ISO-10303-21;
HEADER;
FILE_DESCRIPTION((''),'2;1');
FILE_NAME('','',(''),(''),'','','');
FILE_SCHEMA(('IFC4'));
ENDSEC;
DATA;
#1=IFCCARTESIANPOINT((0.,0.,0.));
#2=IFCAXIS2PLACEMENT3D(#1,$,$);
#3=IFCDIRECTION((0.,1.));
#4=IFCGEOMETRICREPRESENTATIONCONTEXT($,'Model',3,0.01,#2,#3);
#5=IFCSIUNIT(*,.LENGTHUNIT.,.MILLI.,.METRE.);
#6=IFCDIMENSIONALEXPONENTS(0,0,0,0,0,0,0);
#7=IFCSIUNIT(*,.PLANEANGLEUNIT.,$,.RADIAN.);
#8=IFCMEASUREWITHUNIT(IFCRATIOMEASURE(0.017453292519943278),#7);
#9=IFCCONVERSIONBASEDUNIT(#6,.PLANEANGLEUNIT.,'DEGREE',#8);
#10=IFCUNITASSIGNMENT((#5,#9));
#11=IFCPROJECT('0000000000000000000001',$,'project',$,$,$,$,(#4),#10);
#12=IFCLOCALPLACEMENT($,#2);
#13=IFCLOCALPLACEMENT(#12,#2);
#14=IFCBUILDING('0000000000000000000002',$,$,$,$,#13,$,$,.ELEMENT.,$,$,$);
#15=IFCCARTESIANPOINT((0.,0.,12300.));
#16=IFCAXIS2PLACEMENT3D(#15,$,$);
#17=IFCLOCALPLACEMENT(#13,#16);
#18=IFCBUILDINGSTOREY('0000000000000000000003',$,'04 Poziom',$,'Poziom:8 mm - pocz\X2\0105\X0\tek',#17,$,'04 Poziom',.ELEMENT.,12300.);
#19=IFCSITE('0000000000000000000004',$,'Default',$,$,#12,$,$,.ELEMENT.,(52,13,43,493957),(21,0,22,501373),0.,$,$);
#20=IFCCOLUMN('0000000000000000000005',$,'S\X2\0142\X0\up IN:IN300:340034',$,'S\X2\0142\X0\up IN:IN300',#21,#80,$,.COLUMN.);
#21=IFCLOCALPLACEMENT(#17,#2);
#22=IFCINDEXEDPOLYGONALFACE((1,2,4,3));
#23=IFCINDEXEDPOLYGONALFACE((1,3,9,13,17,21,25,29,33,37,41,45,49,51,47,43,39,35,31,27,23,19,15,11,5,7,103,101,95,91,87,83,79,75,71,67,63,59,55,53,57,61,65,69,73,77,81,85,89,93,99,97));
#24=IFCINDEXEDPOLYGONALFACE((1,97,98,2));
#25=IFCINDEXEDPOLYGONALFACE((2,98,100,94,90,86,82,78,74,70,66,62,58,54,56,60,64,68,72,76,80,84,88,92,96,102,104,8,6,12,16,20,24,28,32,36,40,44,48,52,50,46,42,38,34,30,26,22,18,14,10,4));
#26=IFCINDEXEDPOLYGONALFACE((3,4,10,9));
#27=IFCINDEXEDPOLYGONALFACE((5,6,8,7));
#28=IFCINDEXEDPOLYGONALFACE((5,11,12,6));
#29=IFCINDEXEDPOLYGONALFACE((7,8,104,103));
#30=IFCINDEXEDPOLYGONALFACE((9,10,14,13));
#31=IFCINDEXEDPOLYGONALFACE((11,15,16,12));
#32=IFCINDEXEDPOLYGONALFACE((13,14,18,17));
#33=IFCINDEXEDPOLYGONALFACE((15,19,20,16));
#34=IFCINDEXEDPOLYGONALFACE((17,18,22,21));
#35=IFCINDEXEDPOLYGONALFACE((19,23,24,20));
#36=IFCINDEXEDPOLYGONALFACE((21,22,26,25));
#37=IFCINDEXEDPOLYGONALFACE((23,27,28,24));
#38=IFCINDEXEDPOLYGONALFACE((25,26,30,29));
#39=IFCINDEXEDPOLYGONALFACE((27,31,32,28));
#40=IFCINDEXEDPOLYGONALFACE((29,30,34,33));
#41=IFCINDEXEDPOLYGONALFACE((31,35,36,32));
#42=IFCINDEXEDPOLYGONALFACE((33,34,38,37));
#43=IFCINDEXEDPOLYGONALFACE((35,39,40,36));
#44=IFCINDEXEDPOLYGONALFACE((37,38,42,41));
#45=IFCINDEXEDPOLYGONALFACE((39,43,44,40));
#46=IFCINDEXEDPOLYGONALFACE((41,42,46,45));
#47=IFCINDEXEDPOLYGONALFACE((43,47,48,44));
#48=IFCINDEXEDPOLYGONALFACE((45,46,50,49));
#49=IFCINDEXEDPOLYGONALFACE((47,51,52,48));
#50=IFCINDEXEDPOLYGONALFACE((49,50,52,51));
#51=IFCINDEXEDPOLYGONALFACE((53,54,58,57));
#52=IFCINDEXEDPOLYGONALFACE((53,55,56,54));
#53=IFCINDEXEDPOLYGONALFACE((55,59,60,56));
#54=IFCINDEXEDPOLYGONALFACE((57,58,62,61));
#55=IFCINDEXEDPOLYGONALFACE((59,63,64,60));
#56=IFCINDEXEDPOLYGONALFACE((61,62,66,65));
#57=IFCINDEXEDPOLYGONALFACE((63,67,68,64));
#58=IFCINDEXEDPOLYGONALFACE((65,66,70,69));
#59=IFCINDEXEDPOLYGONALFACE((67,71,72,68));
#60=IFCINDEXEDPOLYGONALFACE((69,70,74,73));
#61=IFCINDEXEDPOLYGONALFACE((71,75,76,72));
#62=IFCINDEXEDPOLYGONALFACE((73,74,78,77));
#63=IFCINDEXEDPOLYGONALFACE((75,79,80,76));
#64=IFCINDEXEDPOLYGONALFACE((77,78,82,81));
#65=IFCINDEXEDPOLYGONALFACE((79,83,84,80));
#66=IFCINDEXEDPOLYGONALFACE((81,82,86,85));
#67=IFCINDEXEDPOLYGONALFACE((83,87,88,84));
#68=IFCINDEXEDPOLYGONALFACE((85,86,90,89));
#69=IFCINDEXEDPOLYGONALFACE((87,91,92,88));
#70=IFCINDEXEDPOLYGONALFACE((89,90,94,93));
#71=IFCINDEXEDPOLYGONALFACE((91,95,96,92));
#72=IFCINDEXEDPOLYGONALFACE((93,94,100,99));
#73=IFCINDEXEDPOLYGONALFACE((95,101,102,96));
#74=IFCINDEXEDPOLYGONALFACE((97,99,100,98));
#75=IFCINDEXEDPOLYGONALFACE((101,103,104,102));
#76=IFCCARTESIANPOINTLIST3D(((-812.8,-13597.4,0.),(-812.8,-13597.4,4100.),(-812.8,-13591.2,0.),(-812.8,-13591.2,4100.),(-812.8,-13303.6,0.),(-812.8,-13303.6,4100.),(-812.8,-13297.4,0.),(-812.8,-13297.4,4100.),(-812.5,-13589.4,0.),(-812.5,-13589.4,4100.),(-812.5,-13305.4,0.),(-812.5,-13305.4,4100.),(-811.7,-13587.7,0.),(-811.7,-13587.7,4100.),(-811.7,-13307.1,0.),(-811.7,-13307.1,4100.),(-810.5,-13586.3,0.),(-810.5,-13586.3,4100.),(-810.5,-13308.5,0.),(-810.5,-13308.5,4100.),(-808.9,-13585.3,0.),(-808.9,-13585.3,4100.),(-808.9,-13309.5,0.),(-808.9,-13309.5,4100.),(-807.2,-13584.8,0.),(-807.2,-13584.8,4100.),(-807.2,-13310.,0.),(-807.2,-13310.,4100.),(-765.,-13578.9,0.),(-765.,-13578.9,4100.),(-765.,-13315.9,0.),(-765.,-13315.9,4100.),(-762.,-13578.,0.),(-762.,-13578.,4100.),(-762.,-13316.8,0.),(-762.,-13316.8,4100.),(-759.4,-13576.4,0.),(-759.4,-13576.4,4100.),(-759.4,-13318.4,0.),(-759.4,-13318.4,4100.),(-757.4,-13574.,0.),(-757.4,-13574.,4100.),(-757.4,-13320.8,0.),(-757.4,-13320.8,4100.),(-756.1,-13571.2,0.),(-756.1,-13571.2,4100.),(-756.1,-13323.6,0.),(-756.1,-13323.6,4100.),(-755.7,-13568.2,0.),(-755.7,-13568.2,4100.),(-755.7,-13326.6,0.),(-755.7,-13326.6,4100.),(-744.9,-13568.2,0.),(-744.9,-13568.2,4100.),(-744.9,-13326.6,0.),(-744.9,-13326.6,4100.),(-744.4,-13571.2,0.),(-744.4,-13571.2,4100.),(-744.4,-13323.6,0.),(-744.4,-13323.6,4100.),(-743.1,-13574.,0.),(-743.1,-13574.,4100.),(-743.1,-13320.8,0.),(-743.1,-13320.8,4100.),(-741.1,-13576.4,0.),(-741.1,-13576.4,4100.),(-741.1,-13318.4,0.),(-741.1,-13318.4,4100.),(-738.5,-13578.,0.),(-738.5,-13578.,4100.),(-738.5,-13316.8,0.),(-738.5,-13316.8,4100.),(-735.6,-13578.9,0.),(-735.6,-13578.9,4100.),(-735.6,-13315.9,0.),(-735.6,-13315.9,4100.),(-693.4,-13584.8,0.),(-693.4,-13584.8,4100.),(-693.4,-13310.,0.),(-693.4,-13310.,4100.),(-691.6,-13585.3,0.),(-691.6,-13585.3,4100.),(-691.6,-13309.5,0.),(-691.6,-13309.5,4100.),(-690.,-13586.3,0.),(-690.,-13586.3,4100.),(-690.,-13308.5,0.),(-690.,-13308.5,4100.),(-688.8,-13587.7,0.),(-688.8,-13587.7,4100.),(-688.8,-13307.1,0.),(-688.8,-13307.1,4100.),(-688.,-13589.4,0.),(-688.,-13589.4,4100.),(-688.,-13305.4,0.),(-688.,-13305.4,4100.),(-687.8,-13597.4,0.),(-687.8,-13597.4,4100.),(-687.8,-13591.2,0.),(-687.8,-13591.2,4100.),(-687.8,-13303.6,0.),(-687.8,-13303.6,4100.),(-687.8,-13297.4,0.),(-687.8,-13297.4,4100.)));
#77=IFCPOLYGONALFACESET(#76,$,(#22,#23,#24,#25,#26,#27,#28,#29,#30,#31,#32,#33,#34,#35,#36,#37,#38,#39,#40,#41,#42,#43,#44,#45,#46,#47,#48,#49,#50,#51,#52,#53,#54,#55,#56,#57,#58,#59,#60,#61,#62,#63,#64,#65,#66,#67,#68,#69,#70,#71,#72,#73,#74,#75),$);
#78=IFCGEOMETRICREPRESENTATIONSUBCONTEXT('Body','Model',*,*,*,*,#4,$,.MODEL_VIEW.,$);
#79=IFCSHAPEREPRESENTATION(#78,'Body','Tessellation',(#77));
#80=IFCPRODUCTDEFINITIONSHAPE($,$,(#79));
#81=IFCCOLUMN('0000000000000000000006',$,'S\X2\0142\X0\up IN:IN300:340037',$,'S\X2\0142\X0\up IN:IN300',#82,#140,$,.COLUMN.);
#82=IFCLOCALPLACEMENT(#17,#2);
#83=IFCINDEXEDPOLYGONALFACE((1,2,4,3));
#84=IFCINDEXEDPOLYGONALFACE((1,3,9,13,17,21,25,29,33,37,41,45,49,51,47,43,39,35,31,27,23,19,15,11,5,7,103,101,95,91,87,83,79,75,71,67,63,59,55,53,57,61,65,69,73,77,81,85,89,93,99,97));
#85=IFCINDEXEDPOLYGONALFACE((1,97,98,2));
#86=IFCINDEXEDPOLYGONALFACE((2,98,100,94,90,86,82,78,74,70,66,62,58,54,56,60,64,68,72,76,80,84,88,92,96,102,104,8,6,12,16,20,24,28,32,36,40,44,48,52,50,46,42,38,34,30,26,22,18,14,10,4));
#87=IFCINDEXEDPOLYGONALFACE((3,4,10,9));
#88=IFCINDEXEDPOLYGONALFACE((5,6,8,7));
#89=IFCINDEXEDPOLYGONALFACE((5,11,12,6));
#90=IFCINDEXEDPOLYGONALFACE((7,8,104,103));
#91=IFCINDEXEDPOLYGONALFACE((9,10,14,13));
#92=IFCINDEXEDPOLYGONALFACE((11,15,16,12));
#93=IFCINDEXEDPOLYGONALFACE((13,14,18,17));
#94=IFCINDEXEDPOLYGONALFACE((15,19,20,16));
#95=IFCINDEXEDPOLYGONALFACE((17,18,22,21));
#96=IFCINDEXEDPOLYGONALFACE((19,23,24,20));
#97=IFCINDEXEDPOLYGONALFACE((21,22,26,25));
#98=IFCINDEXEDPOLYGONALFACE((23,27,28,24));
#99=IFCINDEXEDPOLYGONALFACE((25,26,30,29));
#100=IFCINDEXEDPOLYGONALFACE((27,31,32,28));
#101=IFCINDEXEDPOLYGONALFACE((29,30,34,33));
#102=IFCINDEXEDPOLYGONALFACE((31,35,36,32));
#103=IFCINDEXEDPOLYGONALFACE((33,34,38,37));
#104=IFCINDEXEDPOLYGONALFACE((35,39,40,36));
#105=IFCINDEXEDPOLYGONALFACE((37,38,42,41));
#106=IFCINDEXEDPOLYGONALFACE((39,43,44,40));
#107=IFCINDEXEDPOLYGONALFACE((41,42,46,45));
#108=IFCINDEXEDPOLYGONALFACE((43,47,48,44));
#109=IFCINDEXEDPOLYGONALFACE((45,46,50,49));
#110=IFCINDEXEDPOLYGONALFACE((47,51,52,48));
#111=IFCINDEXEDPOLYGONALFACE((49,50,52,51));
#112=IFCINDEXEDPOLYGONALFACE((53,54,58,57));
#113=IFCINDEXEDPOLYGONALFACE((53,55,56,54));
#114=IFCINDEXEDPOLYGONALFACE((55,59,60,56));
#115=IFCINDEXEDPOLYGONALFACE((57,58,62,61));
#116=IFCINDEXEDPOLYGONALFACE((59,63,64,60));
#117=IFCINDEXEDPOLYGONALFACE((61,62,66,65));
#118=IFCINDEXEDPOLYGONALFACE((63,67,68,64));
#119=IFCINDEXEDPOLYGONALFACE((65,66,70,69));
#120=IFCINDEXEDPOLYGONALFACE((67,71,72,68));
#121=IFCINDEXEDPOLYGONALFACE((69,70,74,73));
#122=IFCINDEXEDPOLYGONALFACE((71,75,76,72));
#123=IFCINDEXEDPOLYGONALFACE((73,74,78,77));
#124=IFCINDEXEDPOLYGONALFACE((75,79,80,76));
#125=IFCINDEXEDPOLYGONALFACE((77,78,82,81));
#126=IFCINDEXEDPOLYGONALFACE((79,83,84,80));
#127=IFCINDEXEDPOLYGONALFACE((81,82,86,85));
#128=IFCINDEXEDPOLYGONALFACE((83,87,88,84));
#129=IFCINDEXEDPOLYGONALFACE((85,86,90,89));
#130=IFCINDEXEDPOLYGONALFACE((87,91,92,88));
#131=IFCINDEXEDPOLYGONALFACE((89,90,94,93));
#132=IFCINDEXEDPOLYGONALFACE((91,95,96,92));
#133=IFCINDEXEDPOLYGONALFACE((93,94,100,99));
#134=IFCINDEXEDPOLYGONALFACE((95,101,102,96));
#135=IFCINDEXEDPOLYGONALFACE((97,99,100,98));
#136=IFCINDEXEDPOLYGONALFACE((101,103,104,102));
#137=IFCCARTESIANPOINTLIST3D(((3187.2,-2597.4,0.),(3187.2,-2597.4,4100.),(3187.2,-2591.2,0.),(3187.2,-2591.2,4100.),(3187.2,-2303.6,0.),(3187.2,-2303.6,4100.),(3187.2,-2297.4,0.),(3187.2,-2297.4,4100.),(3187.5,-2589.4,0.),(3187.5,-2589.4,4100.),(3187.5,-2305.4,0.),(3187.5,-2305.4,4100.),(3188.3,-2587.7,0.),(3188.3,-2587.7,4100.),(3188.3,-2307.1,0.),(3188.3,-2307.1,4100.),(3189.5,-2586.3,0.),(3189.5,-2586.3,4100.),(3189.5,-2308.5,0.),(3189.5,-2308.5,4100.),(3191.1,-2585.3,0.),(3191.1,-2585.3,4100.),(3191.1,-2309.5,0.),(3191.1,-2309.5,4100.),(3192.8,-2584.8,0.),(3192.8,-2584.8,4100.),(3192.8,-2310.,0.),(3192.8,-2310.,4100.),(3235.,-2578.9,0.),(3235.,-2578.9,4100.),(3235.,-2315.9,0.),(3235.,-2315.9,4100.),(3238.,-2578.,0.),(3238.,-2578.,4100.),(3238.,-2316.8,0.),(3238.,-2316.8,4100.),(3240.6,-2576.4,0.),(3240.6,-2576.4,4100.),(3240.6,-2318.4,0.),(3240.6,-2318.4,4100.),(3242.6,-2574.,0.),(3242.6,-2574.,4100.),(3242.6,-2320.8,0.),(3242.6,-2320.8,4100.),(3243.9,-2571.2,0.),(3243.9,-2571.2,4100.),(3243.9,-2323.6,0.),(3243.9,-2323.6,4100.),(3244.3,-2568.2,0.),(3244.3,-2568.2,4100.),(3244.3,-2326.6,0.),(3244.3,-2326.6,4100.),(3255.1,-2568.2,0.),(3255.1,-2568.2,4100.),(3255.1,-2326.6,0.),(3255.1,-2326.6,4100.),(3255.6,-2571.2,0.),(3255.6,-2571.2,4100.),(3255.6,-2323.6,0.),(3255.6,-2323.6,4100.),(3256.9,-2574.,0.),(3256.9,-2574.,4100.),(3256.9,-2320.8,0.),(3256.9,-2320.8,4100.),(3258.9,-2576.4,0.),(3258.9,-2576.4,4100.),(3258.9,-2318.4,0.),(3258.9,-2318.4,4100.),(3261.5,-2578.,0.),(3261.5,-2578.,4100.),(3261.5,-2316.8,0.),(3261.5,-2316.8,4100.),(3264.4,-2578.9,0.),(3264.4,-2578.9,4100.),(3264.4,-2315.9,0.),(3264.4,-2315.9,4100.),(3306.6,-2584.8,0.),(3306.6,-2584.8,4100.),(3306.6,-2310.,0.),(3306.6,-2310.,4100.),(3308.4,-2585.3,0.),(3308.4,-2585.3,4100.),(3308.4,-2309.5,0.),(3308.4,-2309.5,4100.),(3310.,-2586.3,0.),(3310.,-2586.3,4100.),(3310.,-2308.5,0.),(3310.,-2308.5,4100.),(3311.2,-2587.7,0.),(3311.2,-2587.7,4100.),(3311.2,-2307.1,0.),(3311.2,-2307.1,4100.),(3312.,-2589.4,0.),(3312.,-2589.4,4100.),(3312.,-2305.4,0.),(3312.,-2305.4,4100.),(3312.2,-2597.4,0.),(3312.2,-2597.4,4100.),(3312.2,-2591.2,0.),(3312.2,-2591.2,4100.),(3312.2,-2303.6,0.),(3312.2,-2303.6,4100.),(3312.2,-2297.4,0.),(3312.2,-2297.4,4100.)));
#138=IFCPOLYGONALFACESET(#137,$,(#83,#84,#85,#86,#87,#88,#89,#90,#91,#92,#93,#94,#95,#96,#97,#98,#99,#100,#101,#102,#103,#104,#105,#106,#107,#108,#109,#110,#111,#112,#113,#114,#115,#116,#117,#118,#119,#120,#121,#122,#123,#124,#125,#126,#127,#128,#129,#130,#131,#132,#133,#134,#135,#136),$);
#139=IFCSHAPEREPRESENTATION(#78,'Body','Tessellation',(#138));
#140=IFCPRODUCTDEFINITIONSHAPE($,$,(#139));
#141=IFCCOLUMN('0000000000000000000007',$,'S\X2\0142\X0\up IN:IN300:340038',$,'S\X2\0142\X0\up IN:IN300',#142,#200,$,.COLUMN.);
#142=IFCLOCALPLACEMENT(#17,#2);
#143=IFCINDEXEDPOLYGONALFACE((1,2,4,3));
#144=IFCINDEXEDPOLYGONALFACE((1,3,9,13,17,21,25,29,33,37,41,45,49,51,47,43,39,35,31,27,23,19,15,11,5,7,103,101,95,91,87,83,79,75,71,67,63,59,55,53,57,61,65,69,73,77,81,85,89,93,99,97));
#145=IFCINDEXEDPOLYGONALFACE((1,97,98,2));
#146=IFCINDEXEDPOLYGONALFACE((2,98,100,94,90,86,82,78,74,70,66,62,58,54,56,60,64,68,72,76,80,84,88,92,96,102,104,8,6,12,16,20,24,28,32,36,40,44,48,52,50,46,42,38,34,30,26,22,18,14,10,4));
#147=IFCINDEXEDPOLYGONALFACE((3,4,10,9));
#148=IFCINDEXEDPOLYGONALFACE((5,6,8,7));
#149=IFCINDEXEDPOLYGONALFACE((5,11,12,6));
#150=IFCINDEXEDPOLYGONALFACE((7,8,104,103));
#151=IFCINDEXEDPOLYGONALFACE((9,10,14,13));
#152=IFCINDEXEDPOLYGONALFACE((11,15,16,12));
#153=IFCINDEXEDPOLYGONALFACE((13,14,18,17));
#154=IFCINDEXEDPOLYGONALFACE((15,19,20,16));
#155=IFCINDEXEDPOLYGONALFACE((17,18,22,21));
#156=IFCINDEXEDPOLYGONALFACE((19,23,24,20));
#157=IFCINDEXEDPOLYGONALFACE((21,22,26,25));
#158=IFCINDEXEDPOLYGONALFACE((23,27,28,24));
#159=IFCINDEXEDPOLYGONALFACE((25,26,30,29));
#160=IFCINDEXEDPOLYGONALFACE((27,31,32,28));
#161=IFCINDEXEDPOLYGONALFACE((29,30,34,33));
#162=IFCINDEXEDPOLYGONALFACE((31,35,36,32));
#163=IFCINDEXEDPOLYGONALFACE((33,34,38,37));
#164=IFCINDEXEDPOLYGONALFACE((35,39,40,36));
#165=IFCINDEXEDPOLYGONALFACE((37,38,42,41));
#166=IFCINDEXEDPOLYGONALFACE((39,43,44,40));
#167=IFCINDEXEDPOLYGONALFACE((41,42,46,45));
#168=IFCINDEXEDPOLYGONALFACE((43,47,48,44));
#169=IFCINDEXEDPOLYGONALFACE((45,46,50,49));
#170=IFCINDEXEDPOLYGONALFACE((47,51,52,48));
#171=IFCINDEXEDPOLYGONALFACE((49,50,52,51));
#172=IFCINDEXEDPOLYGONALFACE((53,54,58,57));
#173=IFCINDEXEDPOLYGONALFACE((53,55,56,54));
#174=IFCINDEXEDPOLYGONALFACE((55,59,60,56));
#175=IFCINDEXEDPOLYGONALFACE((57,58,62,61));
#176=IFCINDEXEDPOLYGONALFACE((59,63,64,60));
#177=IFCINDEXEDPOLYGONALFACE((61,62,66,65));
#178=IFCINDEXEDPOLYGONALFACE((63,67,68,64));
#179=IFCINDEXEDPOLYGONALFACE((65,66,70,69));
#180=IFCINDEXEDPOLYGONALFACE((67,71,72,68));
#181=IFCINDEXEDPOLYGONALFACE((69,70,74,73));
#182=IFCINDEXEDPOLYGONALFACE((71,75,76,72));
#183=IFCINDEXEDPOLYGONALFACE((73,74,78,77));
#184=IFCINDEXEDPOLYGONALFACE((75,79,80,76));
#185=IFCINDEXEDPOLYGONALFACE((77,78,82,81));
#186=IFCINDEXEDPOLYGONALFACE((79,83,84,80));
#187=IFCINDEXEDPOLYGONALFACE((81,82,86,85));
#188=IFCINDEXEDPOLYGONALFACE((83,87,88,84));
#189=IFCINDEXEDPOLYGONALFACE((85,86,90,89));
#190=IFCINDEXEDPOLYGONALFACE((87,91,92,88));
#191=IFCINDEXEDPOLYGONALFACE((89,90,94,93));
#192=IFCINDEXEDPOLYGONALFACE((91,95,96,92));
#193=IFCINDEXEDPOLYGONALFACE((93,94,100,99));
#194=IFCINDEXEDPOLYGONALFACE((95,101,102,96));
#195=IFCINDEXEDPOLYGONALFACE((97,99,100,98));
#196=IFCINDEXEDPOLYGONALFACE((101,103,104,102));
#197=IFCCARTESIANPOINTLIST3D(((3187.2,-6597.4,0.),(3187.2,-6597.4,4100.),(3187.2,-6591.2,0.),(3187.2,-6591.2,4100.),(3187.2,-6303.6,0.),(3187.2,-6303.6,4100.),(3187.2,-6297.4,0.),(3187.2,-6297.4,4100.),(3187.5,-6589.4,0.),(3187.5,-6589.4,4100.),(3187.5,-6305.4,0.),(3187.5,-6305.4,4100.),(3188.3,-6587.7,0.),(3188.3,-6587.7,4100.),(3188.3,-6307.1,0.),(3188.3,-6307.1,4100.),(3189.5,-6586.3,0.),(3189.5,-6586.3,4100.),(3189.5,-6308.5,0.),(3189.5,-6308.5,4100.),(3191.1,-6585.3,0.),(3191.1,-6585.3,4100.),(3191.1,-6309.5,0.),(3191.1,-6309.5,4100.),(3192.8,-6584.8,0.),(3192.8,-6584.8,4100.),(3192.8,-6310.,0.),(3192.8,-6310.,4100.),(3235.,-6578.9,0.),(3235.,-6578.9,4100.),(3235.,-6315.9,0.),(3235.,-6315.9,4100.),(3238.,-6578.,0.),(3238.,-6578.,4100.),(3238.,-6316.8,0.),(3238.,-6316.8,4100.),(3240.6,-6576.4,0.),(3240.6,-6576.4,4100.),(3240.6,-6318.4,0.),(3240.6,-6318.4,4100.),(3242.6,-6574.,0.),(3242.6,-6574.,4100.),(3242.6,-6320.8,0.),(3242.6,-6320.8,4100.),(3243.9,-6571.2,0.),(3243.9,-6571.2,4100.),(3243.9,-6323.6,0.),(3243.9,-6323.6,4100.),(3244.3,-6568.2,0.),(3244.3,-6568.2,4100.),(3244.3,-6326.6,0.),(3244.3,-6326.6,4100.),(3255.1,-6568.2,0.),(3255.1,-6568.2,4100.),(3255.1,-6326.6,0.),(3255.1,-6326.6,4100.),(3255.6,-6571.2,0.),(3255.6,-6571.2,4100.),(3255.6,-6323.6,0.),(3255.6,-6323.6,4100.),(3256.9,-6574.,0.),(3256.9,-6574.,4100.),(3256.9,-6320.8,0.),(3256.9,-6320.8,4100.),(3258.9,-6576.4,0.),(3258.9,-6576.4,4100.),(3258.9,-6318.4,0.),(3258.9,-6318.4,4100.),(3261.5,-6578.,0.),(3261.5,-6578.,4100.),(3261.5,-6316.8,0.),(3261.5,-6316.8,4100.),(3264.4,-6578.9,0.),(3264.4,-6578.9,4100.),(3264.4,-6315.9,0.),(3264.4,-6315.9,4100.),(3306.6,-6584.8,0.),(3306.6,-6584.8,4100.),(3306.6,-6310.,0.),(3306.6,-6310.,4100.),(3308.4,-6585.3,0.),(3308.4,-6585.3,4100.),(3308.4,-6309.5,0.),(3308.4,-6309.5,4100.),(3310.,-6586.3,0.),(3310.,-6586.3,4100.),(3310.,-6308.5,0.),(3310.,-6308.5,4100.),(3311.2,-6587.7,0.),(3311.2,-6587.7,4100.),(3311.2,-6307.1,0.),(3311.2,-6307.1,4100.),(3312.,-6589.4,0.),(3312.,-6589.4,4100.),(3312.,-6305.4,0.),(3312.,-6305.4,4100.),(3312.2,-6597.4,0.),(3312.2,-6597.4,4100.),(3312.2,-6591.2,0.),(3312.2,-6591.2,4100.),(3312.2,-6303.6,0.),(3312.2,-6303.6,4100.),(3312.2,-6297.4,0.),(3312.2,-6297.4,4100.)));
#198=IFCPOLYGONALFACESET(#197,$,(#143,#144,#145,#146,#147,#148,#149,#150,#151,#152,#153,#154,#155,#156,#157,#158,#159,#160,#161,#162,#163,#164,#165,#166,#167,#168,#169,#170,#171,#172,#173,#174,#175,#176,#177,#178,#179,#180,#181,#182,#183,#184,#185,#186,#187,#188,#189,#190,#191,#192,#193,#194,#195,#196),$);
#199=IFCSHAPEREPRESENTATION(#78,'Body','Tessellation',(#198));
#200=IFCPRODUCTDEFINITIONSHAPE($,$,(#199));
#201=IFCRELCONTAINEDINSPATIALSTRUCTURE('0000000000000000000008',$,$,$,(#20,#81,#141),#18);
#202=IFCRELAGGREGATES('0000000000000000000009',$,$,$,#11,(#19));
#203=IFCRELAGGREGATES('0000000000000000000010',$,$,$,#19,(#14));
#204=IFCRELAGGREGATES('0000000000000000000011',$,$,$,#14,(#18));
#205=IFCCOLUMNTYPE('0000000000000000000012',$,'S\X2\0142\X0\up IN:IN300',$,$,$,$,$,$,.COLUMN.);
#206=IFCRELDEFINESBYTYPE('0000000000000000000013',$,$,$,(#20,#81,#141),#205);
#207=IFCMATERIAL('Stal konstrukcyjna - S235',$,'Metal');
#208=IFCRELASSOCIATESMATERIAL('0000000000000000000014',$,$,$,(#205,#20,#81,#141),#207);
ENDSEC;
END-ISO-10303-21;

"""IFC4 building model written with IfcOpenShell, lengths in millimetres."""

from ifc_helpers import new_model, entity, si_unit, converted_unit, direction, frame, origin, place, context, subcontext, project, spatial, line, arc, indexed_curve, outline, extrude, source, transform, mapped, material, type_object, type_shapes, element, save


model = new_model("IFC4")

# Units and contexts
model_context = context("Model", 3, precision=0.01, world=origin(), true_north=direction((0.0, 1.0)))
body_context = subcontext(model_context, "Body", "Model", "MODEL_VIEW")
ifc_project = project(units=[si_unit("LENGTHUNIT", "METRE", prefix="MILLI"), converted_unit("PLANEANGLEUNIT", "DEGREE", entity("IfcRatioMeasure", 0.017453292519943278), si_unit("PLANEANGLEUNIT", "RADIAN"), dimensions=[0, 0, 0, 0, 0, 0, 0])], contexts=[model_context])

# Site, building, storey
site_placement = place(None, origin())
site = spatial("IfcSite", under=ifc_project, at=site_placement, Name="Default", CompositionType="ELEMENT", RefLatitude=(52, 13, 43, 493957), RefLongitude=(21, 0, 22, 501373), RefElevation=0.0)
building_placement = place(site_placement, origin())
building = spatial("IfcBuilding", under=site, at=building_placement, CompositionType="ELEMENT")
storey_placement = place(building_placement, frame((0.0, 0.0, 12300.0)))
storey = spatial("IfcBuildingStorey", under=building, at=storey_placement, Name="04 Poziom", ObjectType="Poziom:8 mm - początek", LongName="04 Poziom", CompositionType="ELEMENT", Elevation=12300.0)

# Columns
ifc_material = material(Name="Stal konstrukcyjna - S235", Category="Metal")
column_type = type_object("IfcColumnType", Name="Słup IN:IN300", PredefinedType="COLUMN", material=ifc_material)
shared_shape_1 = source(origin(), body_context, "Body", "SweptSolid", [
    extrude(outline(indexed_curve([(143.8, -62.5), (150.0, -62.5), (150.0, 62.5), (143.8, 62.5), (139.6, 60.9), (137.4, 56.9), (131.5, 14.7), (127.9, 8.1), (120.8, 5.4), (-120.8, 5.4), (-127.9, 8.1), (-131.5, 14.7), (-137.4, 56.9), (-139.6, 60.9), (-143.8, 62.5), (-150.0, 62.5), (-150.0, -62.5), (-143.8, -62.5), (-139.6, -60.9), (-137.4, -56.9), (-131.5, -14.7), (-127.9, -8.1), (-120.8, -5.4), (120.8, -5.4), (127.9, -8.1), (131.5, -14.7), (137.4, -56.9), (139.6, -60.9)], segments=[line(1, 2, 3, 4), arc(4, 5, 6), line(6, 7), arc(7, 8, 9), line(9, 10), arc(10, 11, 12), line(12, 13), arc(13, 14, 15), line(15, 16, 17, 18), arc(18, 19, 20), line(20, 21), arc(21, 22, 23), line(23, 24), arc(24, 25, 26), line(26, 27), arc(27, 28, 1)], self_intersect=False)), frame((0.0, 0.0, 12300.0), z_axis=(0.0, 0.0, 1.0), x_axis=(0.0, -1.0, 0.0)), (0.0, 0.0, 1.0), 4100.0),
])
type_shapes(column_type, [shared_shape_1])
for number, where, name in (
    (1, (-750.3, -13447.4, -12300.0), "Słup IN:IN300:340034"),
    (2, (3249.7, -2447.4, -12300.0), "Słup IN:IN300:340037"),
    (3, (3249.7, -6447.4, -12300.0), "Słup IN:IN300:340038"),
):
    element("IfcColumn", number, at=place(storey_placement, frame(where)), inside=storey, type_object=column_type, material=ifc_material, Name=name, ObjectType="Słup IN:IN300", PredefinedType="COLUMN", context=body_context, shape_type="MappedRepresentation", body=[
        mapped(shared_shape_1, transform((0.0, 0.0, 0.0), scale=1.0)),
    ])

save(model, "model.ifc")
